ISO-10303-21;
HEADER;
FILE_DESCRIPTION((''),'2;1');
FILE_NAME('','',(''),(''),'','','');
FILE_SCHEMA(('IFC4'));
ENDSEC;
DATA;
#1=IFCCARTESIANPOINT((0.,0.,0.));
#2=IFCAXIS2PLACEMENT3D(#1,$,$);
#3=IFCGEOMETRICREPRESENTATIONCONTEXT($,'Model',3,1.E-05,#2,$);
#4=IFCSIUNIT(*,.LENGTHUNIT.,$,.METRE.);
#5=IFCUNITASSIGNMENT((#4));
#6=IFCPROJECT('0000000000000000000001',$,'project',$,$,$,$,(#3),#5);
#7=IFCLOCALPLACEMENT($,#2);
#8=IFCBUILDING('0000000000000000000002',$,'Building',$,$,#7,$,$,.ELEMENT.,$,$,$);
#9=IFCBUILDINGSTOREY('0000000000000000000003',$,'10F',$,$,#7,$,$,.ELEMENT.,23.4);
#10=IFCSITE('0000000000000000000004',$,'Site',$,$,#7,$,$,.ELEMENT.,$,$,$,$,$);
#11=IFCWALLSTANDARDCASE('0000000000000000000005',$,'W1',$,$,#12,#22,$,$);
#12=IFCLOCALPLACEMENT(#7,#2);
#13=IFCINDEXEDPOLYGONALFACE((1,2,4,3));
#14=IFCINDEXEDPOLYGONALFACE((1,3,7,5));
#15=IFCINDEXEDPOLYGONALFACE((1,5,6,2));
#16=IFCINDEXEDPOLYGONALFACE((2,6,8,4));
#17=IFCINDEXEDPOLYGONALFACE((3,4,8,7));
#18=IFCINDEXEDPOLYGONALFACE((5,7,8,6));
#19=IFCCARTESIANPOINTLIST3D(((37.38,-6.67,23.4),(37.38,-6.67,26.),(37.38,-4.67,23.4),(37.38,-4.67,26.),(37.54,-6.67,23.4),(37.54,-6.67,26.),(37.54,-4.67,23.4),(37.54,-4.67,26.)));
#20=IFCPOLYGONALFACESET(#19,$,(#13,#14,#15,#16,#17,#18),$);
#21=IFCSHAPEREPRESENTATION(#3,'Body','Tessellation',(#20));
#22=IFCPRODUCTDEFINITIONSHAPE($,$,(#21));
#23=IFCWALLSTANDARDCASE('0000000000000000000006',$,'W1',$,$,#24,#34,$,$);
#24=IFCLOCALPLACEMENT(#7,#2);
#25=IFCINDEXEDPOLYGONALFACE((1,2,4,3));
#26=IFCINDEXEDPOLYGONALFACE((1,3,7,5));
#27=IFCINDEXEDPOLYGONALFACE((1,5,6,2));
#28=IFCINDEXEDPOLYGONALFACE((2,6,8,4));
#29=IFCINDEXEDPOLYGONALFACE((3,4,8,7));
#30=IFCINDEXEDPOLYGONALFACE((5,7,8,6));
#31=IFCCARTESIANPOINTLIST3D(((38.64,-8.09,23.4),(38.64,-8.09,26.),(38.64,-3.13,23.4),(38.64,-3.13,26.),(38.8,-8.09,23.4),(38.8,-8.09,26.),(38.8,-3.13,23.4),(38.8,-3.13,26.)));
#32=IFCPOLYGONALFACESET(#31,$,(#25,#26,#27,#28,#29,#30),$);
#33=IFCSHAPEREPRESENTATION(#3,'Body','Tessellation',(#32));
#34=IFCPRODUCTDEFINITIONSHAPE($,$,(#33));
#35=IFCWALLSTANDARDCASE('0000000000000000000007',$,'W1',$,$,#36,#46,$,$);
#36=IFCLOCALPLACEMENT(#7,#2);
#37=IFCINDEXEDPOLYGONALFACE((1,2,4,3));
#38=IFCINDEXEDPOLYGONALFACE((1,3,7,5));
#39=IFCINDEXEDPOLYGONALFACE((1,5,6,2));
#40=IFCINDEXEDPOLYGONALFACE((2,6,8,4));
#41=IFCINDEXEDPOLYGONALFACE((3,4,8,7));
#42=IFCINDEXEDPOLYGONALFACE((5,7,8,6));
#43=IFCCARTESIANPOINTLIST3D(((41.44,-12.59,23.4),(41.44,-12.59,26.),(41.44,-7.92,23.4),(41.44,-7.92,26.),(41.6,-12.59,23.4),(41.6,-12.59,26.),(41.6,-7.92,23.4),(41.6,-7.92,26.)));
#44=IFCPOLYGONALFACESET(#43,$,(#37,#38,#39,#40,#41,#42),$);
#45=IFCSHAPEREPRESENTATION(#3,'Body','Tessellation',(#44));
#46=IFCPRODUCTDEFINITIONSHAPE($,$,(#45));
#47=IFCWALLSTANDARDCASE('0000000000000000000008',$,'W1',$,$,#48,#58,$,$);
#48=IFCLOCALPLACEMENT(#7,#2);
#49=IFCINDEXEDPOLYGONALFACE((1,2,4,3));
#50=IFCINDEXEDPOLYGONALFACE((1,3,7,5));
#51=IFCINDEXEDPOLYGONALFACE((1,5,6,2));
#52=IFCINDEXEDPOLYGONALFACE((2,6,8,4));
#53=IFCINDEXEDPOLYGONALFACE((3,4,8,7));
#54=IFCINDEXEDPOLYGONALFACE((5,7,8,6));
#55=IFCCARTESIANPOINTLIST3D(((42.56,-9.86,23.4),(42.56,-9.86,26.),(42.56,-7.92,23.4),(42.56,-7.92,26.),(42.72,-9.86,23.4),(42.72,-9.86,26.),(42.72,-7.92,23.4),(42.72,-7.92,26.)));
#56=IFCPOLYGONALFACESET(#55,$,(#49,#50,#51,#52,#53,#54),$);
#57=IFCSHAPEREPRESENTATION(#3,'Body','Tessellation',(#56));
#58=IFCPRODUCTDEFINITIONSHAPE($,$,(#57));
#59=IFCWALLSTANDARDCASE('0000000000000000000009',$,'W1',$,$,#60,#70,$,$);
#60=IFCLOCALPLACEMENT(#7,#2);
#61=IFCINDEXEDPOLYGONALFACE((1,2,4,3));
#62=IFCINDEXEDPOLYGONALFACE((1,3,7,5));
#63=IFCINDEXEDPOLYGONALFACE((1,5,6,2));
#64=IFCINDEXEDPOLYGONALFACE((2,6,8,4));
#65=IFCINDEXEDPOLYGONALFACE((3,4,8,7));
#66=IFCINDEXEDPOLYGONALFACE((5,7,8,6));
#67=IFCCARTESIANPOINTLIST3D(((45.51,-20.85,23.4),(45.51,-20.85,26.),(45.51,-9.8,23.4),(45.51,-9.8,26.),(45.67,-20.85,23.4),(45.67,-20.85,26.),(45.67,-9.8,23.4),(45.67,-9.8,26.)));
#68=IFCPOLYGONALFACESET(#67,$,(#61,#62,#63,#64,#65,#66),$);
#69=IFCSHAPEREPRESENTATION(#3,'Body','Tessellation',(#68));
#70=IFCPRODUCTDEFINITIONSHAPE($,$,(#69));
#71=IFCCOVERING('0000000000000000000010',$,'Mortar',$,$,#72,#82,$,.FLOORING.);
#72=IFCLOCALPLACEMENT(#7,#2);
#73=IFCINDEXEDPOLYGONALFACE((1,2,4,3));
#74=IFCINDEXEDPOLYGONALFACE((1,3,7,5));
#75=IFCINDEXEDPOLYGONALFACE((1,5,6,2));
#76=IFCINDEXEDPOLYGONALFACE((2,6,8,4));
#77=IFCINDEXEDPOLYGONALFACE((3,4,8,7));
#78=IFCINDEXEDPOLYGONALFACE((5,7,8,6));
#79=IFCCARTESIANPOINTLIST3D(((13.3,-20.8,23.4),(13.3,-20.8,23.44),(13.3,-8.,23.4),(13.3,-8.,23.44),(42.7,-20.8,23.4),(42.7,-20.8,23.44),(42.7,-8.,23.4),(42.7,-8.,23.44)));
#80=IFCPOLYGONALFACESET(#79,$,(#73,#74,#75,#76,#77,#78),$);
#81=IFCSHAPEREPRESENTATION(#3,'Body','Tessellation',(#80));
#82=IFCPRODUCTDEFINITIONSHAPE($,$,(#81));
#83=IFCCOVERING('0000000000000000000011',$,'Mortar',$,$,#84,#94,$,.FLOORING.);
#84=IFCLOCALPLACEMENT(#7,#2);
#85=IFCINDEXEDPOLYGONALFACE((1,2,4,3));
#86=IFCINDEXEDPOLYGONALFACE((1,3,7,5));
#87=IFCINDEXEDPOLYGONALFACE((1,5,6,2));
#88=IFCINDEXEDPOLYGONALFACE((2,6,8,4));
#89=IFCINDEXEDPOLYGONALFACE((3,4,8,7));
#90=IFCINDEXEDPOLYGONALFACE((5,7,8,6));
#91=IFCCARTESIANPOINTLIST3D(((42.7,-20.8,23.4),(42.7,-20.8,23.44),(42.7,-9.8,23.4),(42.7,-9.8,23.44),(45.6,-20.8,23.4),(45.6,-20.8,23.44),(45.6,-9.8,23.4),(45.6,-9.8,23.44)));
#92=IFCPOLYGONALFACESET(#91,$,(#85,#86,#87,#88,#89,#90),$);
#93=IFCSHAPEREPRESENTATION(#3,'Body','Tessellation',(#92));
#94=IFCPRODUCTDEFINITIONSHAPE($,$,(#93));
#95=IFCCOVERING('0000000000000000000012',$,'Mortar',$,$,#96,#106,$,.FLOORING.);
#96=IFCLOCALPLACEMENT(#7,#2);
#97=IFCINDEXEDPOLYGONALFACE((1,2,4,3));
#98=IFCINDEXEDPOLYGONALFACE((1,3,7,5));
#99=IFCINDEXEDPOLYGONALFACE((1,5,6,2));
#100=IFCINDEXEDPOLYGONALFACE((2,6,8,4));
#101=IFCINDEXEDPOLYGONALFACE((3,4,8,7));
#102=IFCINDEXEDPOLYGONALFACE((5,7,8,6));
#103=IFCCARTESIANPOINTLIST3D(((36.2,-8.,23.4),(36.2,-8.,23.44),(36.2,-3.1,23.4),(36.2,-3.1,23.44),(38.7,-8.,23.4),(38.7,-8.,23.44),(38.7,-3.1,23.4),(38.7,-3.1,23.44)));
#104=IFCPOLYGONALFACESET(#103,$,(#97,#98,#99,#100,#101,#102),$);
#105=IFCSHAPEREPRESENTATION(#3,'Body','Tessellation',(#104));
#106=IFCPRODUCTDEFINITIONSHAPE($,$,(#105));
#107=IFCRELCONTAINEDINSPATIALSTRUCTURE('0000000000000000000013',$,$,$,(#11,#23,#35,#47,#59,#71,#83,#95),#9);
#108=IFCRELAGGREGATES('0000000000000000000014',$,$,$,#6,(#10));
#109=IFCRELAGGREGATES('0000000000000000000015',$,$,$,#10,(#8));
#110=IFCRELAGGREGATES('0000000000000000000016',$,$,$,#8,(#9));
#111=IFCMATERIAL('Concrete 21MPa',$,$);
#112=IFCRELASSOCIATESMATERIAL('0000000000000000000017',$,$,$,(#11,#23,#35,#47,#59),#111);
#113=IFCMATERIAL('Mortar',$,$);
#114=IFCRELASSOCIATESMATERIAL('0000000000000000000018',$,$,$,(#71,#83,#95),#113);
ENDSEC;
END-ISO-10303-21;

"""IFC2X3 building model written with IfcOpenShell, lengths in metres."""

from ifc_helpers import new_model, si_unit, frame, origin, origin_2d, place, context, project, spatial, rectangle, extrude, material, element, save


model = new_model("IFC2X3")

# Units and contexts
model_context = context("Model", 3, precision=1e-05, world=origin())
ifc_project = project(units=[si_unit("LENGTHUNIT", "METRE")], contexts=[model_context])

# Site, building, storey
placement = place(None, origin())
site = spatial("IfcSite", under=ifc_project, at=placement, Name="Site", CompositionType="ELEMENT")
building = spatial("IfcBuilding", under=site, at=placement, Name="Building", CompositionType="ELEMENT")
storey = spatial("IfcBuildingStorey", under=building, at=placement, Name="10F", CompositionType="ELEMENT", Elevation=23.4)

# Shared definitions
ifc_material_1 = material(Name="Concrete 21MPa")

# Walls
wall_1_placement = place(None, frame((37.46, -5.67, 23.4)))
element("IfcWallStandardCase", 1, at=wall_1_placement, inside=storey, material=ifc_material_1, Name="W1", context=model_context, shape_type="SweptSolid", body=[
    extrude(rectangle(XDim=0.16, YDim=2.0, at=origin_2d()), origin(), (0.0, 0.0, 1.0), 2.6),
])
wall_2_placement = place(None, frame((38.72, -5.61, 23.4)))
element("IfcWallStandardCase", 2, at=wall_2_placement, inside=storey, material=ifc_material_1, Name="W1", context=model_context, shape_type="SweptSolid", body=[
    extrude(rectangle(XDim=0.16, YDim=4.96, at=origin_2d()), origin(), (0.0, 0.0, 1.0), 2.6),
])
wall_3_placement = place(None, frame((41.52, -10.255, 23.4)))
element("IfcWallStandardCase", 3, at=wall_3_placement, inside=storey, material=ifc_material_1, Name="W1", context=model_context, shape_type="SweptSolid", body=[
    extrude(rectangle(XDim=0.16, YDim=4.67, at=origin_2d()), origin(), (0.0, 0.0, 1.0), 2.6),
])
wall_4_placement = place(None, frame((42.64, -8.89, 23.4)))
element("IfcWallStandardCase", 4, at=wall_4_placement, inside=storey, material=ifc_material_1, Name="W1", context=model_context, shape_type="SweptSolid", body=[
    extrude(rectangle(XDim=0.16, YDim=1.94, at=origin_2d()), origin(), (0.0, 0.0, 1.0), 2.6),
])
wall_5_placement = place(None, frame((45.59, -15.325, 23.4)))
element("IfcWallStandardCase", 5, at=wall_5_placement, inside=storey, material=ifc_material_1, Name="W1", context=model_context, shape_type="SweptSolid", body=[
    extrude(rectangle(XDim=0.16, YDim=11.05, at=origin_2d()), origin(), (0.0, 0.0, 1.0), 2.6),
])

# Coverings
ifc_material_2 = material(Name="Mortar")
covering_1_placement = place(None, frame((28.0, -14.4, 23.4)))
element("IfcCovering", 6, at=covering_1_placement, inside=storey, material=ifc_material_2, Name="Mortar", PredefinedType="FLOORING", context=model_context, shape_type="SweptSolid", body=[
    extrude(rectangle(XDim=29.4, YDim=12.8, at=origin_2d()), origin(), (0.0, 0.0, 1.0), 0.04),
])
covering_2_placement = place(None, frame((44.15, -15.3, 23.4)))
element("IfcCovering", 7, at=covering_2_placement, inside=storey, material=ifc_material_2, Name="Mortar", PredefinedType="FLOORING", context=model_context, shape_type="SweptSolid", body=[
    extrude(rectangle(XDim=2.9, YDim=11.0, at=origin_2d()), origin(), (0.0, 0.0, 1.0), 0.04),
])
covering_3_placement = place(None, frame((37.45, -5.55, 23.4)))
element("IfcCovering", 8, at=covering_3_placement, inside=storey, material=ifc_material_2, Name="Mortar", PredefinedType="FLOORING", context=model_context, shape_type="SweptSolid", body=[
    extrude(rectangle(XDim=2.5, YDim=4.9, at=origin_2d()), origin(), (0.0, 0.0, 1.0), 0.04),
])

save(model, "model.ifc")
